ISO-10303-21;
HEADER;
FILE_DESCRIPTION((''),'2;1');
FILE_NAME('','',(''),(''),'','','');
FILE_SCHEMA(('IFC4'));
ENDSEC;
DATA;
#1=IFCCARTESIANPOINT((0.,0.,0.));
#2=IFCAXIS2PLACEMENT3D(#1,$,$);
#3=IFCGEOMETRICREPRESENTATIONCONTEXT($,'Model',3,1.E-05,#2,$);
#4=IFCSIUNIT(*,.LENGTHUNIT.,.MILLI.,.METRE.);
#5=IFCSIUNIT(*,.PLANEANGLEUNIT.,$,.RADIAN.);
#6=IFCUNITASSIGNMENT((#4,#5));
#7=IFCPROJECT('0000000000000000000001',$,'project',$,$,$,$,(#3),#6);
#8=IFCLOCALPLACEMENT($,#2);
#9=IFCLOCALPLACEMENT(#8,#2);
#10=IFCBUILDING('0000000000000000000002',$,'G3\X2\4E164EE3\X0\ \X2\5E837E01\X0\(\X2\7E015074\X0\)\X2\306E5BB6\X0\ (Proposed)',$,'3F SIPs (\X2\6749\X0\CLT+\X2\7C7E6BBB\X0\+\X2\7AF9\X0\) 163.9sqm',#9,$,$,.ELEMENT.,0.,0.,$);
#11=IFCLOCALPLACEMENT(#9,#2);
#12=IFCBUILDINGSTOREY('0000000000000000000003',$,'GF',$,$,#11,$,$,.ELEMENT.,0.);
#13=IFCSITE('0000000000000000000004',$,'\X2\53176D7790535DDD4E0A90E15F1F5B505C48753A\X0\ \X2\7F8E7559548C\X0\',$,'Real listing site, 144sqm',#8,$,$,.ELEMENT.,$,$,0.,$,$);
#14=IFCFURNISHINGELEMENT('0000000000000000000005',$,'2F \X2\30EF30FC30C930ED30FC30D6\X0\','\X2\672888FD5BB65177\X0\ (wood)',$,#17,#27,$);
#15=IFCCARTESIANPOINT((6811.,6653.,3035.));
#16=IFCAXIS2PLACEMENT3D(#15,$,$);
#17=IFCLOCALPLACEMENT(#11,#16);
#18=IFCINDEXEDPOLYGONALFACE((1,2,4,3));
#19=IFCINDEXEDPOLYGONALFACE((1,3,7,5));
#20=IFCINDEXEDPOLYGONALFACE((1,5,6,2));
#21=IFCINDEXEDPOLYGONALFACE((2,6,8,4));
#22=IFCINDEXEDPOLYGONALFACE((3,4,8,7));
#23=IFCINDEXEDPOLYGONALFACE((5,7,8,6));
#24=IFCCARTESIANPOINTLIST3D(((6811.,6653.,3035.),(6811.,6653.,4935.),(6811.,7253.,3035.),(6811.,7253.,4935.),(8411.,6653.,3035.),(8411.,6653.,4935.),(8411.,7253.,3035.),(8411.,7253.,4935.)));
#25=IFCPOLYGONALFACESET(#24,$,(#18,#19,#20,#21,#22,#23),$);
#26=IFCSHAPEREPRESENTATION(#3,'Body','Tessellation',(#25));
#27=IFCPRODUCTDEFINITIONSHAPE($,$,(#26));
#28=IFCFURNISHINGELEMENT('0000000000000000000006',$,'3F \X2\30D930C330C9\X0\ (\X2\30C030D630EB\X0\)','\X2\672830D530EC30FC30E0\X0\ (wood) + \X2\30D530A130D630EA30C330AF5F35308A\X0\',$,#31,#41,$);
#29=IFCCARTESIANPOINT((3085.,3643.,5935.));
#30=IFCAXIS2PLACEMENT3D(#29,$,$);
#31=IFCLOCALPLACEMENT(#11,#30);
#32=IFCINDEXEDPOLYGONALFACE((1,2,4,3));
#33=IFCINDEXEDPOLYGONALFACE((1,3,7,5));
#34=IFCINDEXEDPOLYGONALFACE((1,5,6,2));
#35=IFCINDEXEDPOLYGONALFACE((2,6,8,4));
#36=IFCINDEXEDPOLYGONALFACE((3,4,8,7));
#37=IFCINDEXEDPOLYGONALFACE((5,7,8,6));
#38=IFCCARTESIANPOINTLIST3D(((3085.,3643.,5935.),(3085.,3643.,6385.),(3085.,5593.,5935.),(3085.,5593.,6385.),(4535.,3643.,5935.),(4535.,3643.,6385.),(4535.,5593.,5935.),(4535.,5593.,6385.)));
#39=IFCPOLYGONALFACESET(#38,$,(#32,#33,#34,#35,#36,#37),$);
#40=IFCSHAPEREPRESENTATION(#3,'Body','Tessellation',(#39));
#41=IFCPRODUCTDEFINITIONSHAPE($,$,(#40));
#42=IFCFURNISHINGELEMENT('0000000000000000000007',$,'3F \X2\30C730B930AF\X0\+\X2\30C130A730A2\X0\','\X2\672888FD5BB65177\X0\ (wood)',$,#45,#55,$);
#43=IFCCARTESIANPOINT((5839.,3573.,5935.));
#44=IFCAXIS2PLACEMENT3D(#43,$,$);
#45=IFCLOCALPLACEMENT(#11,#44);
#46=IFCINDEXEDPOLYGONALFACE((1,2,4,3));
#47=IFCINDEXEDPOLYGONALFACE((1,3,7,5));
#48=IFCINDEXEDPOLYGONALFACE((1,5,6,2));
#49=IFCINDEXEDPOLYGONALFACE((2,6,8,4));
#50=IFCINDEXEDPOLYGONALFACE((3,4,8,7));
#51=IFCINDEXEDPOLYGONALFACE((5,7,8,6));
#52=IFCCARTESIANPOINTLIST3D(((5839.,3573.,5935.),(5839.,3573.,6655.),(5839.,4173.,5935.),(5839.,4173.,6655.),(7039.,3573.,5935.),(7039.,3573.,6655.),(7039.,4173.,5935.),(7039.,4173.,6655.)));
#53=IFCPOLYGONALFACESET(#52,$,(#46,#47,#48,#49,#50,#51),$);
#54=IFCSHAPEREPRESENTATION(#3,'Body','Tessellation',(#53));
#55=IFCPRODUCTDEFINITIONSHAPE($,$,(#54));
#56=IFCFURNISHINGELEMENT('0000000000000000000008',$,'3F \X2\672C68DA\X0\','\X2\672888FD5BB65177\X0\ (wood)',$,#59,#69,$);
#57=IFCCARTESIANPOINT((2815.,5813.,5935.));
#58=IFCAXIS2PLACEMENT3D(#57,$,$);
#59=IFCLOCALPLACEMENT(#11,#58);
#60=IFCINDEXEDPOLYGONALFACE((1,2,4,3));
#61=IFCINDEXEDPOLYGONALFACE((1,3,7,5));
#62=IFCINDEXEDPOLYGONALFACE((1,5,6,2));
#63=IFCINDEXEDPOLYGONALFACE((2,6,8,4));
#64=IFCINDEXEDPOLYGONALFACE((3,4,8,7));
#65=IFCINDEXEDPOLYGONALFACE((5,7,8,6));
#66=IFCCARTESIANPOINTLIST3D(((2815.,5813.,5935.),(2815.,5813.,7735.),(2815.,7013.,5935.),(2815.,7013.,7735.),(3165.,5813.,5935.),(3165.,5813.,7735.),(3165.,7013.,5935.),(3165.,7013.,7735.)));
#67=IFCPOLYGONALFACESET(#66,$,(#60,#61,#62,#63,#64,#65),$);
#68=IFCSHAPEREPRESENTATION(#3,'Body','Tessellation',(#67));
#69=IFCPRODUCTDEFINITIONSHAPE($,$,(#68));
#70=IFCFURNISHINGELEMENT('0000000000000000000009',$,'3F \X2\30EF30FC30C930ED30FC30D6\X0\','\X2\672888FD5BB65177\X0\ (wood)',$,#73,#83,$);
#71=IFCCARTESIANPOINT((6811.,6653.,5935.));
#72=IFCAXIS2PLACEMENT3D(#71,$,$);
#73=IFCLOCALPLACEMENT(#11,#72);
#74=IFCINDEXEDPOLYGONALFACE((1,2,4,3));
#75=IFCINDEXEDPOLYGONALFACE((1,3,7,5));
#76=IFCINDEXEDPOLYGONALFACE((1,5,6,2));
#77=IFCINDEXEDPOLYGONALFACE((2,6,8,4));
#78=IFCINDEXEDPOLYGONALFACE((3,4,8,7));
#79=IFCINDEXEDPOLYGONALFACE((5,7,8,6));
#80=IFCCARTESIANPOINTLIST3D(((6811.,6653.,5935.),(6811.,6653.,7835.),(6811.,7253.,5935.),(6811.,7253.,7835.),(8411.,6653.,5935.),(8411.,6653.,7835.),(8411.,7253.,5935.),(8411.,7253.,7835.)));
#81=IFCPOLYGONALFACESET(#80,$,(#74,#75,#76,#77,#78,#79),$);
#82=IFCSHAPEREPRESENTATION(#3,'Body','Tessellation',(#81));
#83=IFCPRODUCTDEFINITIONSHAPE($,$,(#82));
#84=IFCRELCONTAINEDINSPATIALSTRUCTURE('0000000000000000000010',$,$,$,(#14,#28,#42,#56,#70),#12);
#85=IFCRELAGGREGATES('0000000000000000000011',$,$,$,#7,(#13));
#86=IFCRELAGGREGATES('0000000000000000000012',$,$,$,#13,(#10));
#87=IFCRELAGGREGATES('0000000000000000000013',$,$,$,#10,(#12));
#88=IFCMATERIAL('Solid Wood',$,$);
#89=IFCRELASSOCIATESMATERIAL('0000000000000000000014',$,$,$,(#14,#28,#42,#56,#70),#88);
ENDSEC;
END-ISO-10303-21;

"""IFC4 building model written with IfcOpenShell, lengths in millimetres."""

from ifc_helpers import new_model, si_unit, frame, frame_2d, origin, place, context, project, spatial, rectangle, extrude, material, element, save


model = new_model("IFC4")

# Units and contexts
model_context = context("Model", 3, precision=1e-05, world=origin())
ifc_project = project(units=[si_unit("LENGTHUNIT", "METRE", prefix="MILLI"), si_unit("PLANEANGLEUNIT", "RADIAN")], contexts=[model_context])

# Site, building, storey
site_placement = place(None, origin())
site = spatial("IfcSite", under=ifc_project, at=site_placement, Name="北海道川上郡弟子屈町 美留和", ObjectType="Real listing site, 144sqm", CompositionType="ELEMENT", RefElevation=0.0)
building_placement = place(site_placement, origin())
building = spatial("IfcBuilding", under=site, at=building_placement, Name="G3世代 広縁(縁側)の家 (Proposed)", ObjectType="3F SIPs (杉CLT+籾殻+竹) 163.9sqm", CompositionType="ELEMENT", ElevationOfRefHeight=0.0, ElevationOfTerrain=0.0)
storey_placement = place(building_placement, origin())
storey = spatial("IfcBuildingStorey", under=building, at=storey_placement, Name="GF", CompositionType="ELEMENT", Elevation=0.0)

# Shared definitions
ifc_material_1 = material(Name="Solid Wood")

# Furnishing elements
furnishing_1_placement = place(storey_placement, frame((6811.0, 6653.0, 3035.0)))
element("IfcFurnishingElement", 1, at=furnishing_1_placement, inside=storey, material=ifc_material_1, Name="2F ワードローブ", Description="木製家具 (wood)", context=model_context, shape_type="SweptSolid", body=[
    extrude(rectangle(XDim=1600.0, YDim=600.0, at=frame_2d((800.0, 300.0))), frame((6811.0, 6653.0, 3035.0)), (0.0, 0.0, 1.0), 1900.0),
])
furnishing_2_placement = place(storey_placement, frame((3085.0, 3643.0, 5935.0)))
element("IfcFurnishingElement", 2, at=furnishing_2_placement, inside=storey, material=ifc_material_1, Name="3F ベッド (ダブル)", Description="木フレーム (wood) + ファブリック張り", context=model_context, shape_type="SweptSolid", body=[
    extrude(rectangle(XDim=1450.0, YDim=1950.0, at=frame_2d((725.0, 975.0))), frame((3085.0, 3643.0, 5935.0)), (0.0, 0.0, 1.0), 450.0),
])
furnishing_3_placement = place(storey_placement, frame((5839.0, 3573.0, 5935.0)))
element("IfcFurnishingElement", 3, at=furnishing_3_placement, inside=storey, material=ifc_material_1, Name="3F デスク+チェア", Description="木製家具 (wood)", context=model_context, shape_type="SweptSolid", body=[
    extrude(rectangle(XDim=1200.0, YDim=600.0, at=frame_2d((600.0, 300.0))), frame((5839.0, 3573.0, 5935.0)), (0.0, 0.0, 1.0), 720.0),
])
furnishing_4_placement = place(storey_placement, frame((2815.0, 5813.0, 5935.0)))
element("IfcFurnishingElement", 4, at=furnishing_4_placement, inside=storey, material=ifc_material_1, Name="3F 本棚", Description="木製家具 (wood)", context=model_context, shape_type="SweptSolid", body=[
    extrude(rectangle(XDim=350.0, YDim=1200.0, at=frame_2d((175.0, 600.0))), frame((2815.0, 5813.0, 5935.0)), (0.0, 0.0, 1.0), 1800.0),
])
furnishing_5_placement = place(storey_placement, frame((6811.0, 6653.0, 5935.0)))
element("IfcFurnishingElement", 5, at=furnishing_5_placement, inside=storey, material=ifc_material_1, Name="3F ワードローブ", Description="木製家具 (wood)", context=model_context, shape_type="SweptSolid", body=[
    extrude(rectangle(XDim=1600.0, YDim=600.0, at=frame_2d((800.0, 300.0))), frame((6811.0, 6653.0, 5935.0)), (0.0, 0.0, 1.0), 1900.0),
])

save(model, "model.ifc")
